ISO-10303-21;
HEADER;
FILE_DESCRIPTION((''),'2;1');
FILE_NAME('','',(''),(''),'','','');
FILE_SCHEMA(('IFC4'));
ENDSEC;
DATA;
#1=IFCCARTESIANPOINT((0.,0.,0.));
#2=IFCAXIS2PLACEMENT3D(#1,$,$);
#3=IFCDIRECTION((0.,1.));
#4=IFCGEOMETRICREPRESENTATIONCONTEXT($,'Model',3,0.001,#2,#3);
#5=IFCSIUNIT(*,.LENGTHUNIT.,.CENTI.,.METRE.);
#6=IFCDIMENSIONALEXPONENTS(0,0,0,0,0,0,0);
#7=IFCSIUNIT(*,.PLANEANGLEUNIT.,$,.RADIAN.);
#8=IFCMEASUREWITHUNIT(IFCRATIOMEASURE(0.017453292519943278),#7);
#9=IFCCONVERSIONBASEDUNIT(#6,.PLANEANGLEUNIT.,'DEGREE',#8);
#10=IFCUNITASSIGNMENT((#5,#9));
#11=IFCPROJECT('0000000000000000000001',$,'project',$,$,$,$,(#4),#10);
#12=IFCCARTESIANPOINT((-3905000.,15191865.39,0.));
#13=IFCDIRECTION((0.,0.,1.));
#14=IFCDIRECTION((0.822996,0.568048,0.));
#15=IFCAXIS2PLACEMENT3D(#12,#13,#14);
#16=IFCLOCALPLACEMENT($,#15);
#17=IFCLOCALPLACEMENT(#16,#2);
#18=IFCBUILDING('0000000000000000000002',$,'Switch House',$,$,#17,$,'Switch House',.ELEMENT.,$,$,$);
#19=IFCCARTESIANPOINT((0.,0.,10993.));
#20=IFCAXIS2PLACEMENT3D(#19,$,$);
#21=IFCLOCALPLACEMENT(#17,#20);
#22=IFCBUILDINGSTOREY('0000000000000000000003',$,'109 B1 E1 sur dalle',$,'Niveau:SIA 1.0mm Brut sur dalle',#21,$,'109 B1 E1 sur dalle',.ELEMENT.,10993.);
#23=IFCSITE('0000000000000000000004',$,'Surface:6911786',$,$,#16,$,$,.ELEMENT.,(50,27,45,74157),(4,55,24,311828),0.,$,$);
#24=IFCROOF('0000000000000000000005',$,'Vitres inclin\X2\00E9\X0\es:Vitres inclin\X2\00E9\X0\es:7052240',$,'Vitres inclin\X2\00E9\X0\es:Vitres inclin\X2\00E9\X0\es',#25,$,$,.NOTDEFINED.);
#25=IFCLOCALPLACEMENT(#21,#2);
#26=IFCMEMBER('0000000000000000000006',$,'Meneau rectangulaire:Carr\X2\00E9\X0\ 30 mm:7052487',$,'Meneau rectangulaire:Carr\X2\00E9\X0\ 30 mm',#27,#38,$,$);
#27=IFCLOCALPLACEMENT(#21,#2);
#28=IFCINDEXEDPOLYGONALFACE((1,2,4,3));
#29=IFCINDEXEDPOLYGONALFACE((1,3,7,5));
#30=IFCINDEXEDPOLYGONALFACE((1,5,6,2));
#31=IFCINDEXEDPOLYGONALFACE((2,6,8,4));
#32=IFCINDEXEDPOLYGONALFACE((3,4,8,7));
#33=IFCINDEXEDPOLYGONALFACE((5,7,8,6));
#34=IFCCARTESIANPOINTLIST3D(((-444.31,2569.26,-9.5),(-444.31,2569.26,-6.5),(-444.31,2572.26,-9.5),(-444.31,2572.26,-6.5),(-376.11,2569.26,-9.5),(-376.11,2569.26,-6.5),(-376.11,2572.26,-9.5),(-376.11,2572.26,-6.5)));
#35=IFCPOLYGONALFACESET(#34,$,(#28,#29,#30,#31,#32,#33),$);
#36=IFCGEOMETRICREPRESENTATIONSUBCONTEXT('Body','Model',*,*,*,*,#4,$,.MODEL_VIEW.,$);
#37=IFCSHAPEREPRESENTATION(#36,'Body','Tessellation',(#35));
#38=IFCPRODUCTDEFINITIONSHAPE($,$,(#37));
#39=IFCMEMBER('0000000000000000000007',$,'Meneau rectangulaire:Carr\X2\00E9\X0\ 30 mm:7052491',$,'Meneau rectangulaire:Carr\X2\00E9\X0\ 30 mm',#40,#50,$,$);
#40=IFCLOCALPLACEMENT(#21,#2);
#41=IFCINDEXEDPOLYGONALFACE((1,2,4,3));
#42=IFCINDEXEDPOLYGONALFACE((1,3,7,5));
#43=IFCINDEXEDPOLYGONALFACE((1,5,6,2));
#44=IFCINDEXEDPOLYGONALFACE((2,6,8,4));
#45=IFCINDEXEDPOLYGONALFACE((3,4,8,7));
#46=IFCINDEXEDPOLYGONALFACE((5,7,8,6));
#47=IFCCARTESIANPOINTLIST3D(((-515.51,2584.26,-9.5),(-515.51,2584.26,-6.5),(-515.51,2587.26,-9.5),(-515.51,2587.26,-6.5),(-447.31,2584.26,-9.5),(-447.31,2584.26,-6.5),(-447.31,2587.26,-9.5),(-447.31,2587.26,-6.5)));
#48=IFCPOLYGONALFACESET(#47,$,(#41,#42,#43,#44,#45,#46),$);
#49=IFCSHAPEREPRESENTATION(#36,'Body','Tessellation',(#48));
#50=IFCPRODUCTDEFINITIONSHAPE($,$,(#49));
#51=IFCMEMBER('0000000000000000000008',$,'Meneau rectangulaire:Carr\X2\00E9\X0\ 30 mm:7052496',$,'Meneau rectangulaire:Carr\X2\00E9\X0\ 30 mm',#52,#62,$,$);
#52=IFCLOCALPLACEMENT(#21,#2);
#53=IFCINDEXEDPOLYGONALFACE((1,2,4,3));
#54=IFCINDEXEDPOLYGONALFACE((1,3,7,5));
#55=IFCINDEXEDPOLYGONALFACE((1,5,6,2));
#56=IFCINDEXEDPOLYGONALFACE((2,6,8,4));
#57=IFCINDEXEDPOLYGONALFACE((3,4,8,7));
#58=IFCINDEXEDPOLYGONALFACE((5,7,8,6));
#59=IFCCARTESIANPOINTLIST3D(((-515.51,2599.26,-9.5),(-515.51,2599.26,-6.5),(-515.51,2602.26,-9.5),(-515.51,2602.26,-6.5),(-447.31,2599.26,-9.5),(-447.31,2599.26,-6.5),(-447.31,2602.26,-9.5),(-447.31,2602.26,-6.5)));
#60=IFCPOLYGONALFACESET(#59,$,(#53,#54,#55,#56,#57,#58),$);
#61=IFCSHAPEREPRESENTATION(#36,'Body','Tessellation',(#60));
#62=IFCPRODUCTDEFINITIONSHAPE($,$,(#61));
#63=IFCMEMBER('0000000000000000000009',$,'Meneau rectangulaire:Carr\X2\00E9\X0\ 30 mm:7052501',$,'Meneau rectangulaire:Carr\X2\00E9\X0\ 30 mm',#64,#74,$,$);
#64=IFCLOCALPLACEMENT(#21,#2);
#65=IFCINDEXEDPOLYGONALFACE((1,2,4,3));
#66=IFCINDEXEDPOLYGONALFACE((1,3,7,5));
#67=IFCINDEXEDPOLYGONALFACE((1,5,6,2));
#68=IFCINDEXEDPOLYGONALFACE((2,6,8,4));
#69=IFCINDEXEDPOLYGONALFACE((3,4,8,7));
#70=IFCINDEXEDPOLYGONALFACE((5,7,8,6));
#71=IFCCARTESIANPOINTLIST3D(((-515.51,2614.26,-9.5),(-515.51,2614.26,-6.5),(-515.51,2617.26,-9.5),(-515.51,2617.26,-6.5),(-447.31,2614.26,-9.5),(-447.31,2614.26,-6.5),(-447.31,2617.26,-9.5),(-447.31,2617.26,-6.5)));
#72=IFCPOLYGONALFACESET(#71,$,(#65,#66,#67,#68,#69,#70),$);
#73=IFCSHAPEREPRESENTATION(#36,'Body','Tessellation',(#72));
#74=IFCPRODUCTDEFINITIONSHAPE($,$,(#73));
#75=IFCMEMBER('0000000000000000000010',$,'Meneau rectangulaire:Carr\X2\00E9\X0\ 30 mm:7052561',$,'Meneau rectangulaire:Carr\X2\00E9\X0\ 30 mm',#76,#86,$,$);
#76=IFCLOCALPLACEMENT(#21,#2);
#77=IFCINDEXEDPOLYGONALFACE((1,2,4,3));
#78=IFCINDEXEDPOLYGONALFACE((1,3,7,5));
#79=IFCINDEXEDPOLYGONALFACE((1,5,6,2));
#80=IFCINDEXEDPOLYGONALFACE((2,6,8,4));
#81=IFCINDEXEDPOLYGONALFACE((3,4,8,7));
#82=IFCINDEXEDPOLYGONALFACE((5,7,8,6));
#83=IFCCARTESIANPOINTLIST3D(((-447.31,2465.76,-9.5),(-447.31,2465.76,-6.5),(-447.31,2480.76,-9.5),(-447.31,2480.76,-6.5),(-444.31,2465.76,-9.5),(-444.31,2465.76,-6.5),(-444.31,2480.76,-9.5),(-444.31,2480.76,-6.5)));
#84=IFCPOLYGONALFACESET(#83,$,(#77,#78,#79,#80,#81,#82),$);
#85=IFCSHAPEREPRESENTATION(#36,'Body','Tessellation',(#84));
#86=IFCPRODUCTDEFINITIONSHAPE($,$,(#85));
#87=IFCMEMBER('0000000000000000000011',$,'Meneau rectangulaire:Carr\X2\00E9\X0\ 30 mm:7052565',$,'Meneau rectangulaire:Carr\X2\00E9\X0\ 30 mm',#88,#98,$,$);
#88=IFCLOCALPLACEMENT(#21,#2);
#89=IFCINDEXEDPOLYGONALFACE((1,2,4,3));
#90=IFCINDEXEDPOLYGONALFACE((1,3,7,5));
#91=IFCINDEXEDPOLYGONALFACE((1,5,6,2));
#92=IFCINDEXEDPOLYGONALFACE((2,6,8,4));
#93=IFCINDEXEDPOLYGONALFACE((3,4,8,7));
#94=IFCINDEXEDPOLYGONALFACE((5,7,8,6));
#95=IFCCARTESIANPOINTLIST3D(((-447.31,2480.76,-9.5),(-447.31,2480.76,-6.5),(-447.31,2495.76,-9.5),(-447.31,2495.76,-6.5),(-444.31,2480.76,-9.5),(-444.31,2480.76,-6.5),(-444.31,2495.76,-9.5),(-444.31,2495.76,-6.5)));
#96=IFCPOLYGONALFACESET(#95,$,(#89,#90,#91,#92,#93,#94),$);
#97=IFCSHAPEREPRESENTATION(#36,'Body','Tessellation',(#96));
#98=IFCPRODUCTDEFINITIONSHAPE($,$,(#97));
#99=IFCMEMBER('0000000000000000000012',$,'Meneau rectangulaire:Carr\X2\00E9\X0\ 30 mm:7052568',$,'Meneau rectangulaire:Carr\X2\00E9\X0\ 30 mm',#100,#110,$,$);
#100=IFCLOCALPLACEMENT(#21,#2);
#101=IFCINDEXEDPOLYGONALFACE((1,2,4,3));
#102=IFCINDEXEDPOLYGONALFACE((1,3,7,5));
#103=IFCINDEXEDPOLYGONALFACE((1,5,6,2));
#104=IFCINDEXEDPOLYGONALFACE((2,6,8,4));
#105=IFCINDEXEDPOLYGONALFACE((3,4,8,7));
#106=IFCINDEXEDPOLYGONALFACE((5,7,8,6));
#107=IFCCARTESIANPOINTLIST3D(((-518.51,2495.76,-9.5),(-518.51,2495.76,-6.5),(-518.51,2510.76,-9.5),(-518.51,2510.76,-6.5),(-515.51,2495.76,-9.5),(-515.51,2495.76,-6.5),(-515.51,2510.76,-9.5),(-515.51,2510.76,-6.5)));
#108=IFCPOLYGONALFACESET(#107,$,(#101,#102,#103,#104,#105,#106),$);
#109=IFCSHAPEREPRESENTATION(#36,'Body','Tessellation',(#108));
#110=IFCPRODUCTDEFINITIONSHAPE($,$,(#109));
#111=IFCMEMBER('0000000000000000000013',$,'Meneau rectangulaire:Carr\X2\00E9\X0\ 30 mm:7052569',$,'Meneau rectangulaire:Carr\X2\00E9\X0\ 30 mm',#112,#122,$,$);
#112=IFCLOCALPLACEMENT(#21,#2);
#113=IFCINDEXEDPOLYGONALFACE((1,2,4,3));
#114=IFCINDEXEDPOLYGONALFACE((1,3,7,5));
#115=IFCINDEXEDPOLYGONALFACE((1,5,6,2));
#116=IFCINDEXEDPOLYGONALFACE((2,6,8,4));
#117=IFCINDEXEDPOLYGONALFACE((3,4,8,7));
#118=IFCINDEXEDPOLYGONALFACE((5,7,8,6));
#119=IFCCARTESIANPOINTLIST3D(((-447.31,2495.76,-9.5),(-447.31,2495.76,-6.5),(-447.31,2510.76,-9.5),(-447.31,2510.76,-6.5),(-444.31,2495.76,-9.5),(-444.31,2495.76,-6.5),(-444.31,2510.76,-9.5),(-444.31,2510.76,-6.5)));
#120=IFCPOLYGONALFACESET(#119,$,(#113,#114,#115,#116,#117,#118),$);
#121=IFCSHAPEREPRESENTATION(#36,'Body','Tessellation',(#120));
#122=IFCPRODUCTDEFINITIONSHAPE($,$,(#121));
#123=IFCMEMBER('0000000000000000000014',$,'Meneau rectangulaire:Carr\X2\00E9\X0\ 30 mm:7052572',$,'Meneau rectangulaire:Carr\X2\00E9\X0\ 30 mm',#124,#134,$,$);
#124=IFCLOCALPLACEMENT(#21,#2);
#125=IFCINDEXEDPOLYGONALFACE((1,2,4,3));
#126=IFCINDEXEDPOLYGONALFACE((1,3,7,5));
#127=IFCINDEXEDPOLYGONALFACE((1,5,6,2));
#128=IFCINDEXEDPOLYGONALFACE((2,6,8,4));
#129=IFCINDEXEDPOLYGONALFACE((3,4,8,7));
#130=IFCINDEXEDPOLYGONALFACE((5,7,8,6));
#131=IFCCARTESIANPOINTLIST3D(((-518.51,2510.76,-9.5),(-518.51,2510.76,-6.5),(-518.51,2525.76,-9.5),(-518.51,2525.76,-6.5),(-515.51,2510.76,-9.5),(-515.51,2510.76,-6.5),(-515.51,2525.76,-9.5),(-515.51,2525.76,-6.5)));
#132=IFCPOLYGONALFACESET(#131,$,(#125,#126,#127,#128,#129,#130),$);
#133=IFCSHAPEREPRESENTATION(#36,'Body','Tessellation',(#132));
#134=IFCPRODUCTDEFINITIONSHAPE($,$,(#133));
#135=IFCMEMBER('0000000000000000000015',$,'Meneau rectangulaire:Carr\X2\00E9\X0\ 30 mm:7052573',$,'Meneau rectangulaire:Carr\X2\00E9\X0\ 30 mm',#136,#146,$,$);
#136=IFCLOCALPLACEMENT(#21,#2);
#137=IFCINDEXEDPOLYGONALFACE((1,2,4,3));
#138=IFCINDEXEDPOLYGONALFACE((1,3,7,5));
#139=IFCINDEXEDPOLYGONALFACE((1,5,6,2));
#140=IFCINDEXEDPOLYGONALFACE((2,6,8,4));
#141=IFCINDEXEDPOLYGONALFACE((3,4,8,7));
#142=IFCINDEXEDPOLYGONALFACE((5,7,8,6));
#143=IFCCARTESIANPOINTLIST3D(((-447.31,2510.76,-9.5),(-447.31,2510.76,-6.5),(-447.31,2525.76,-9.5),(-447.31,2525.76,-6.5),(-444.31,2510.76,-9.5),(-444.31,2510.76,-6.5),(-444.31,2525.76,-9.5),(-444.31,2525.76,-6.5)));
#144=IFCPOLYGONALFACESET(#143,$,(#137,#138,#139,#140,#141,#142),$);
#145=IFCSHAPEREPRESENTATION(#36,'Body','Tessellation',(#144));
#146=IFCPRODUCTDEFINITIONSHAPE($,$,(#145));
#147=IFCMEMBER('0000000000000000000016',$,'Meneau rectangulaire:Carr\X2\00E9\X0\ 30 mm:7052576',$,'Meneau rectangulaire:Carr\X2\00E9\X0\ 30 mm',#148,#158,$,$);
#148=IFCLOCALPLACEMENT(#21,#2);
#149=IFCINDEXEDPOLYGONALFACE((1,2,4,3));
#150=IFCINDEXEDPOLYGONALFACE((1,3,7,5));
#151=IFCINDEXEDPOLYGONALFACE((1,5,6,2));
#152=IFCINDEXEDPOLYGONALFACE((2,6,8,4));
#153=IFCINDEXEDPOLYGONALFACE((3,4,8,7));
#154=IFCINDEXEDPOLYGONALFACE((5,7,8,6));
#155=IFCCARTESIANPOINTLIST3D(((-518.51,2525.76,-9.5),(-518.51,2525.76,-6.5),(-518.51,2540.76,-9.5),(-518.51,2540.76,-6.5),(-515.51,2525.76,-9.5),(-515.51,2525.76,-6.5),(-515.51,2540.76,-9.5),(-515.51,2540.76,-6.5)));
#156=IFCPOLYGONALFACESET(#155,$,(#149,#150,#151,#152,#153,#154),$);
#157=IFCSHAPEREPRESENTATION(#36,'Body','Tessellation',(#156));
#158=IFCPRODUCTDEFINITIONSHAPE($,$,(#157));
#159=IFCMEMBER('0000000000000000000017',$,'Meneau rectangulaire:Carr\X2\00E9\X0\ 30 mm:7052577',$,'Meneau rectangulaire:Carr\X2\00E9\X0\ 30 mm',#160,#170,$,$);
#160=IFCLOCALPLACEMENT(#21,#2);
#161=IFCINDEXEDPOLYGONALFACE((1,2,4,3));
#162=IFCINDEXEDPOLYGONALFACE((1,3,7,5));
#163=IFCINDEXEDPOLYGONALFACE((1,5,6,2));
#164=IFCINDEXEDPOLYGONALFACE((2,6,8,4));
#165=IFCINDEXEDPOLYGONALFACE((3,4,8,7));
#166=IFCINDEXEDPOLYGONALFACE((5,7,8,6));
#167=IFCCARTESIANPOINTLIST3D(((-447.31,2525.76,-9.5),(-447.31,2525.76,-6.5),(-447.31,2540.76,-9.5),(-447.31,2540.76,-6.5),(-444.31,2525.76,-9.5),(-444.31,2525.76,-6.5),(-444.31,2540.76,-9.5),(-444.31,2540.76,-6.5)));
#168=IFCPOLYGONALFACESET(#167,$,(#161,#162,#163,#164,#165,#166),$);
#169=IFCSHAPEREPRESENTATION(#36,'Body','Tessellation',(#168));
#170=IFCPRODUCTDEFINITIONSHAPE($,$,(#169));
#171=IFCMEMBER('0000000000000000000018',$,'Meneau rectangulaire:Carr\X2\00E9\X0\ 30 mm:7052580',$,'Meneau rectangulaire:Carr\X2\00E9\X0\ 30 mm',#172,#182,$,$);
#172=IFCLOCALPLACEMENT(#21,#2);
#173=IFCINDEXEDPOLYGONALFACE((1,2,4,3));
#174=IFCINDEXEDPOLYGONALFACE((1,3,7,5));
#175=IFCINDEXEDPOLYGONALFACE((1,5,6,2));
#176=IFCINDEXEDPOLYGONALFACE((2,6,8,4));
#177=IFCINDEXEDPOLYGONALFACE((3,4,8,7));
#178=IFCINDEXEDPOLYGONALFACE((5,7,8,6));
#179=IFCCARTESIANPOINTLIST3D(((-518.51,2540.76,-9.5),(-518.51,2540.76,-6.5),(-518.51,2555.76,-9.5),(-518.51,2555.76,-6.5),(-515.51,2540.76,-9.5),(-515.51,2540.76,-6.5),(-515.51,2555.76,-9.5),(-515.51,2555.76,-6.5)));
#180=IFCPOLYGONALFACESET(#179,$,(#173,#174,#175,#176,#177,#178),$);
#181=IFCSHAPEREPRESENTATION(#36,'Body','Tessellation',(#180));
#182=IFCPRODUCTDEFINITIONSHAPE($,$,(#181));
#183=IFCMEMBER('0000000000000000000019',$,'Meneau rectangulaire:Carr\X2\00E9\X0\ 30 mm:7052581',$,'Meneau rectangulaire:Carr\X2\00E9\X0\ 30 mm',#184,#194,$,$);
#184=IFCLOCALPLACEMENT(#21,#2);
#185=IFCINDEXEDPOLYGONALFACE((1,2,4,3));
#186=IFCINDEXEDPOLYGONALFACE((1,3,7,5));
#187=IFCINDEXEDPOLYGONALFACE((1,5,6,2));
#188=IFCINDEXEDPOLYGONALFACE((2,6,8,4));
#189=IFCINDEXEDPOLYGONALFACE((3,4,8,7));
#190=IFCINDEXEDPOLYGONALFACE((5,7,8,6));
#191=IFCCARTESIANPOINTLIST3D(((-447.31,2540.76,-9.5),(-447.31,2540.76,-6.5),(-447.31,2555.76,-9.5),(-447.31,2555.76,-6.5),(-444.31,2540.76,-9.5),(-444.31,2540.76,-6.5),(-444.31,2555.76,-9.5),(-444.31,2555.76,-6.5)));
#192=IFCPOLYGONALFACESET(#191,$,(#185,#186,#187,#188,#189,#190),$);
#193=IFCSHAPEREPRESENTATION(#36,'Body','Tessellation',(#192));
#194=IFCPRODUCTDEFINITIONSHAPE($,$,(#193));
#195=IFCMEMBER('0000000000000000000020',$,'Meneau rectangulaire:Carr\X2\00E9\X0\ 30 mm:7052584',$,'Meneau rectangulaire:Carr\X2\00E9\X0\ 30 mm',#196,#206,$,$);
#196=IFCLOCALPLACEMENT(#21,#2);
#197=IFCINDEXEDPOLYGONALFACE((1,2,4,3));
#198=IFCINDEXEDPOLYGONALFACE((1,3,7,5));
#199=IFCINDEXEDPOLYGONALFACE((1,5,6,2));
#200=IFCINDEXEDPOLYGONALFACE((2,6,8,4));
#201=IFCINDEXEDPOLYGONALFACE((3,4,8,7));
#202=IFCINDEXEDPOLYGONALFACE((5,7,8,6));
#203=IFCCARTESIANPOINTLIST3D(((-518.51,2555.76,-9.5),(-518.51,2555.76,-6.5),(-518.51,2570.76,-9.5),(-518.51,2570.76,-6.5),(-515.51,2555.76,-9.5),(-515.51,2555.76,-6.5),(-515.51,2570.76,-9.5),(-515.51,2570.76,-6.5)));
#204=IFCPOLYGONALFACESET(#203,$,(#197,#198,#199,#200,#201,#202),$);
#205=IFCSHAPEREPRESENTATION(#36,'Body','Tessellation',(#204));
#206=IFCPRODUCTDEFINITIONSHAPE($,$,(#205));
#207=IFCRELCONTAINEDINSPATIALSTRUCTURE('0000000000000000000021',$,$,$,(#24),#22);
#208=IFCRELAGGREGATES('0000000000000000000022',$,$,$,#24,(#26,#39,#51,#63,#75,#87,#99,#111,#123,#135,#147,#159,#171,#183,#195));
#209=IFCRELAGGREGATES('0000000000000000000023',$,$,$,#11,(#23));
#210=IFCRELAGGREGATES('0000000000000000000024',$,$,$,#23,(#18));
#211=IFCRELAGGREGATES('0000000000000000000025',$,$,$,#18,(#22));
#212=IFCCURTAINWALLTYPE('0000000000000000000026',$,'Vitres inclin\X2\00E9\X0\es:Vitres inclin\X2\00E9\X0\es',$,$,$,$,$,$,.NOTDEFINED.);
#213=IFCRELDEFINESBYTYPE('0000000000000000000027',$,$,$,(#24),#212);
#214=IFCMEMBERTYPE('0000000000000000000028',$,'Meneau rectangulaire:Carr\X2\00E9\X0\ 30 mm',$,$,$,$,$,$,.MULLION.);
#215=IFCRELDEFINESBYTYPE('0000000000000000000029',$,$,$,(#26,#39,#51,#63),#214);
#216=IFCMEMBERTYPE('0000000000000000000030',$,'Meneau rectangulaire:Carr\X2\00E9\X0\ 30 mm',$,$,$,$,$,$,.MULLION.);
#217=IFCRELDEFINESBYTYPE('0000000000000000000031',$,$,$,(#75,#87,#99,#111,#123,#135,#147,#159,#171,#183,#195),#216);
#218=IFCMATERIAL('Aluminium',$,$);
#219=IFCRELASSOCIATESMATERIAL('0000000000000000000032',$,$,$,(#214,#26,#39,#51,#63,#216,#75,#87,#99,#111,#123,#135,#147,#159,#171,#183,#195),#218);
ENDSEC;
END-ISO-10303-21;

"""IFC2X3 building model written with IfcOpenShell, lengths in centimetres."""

from ifc_helpers import new_model, entity, si_unit, converted_unit, direction, frame, origin, origin_2d_with_axis, place, context, subcontext, project, spatial, rectangle, extrude, source, transform, mapped, material, type_object, type_shapes, element, aggregate, save


model = new_model("IFC2X3")

# Units and contexts
model_context = context("Model", 3, precision=0.001, world=origin(), true_north=direction((0.0, 1.0)))
body_context = subcontext(model_context, "Body", "Model", "MODEL_VIEW")
ifc_project = project(units=[si_unit("LENGTHUNIT", "METRE", prefix="CENTI"), converted_unit("PLANEANGLEUNIT", "DEGREE", entity("IfcRatioMeasure", 0.017453292519943278), si_unit("PLANEANGLEUNIT", "RADIAN"), dimensions=[0, 0, 0, 0, 0, 0, 0])], contexts=[model_context])

# Site, building, storey
site_placement = place(None, frame((-3905000.0, 15191865.39, 0.0), z_axis=(0.0, 0.0, 1.0), x_axis=(0.822996, 0.568048, 0.0)))
site = spatial("IfcSite", under=ifc_project, at=site_placement, Name="Surface:6911786", CompositionType="ELEMENT", RefLatitude=(50, 27, 45, 74157), RefLongitude=(4, 55, 24, 311828), RefElevation=0.0)
building_placement = place(site_placement, origin())
building = spatial("IfcBuilding", under=site, at=building_placement, Name="Switch House", LongName="Switch House", CompositionType="ELEMENT")
storey_placement = place(building_placement, frame((0.0, 0.0, 10993.0)))
storey = spatial("IfcBuildingStorey", under=building, at=storey_placement, Name="109 B1 E1 sur dalle", ObjectType="Niveau:SIA 1.0mm Brut sur dalle", LongName="109 B1 E1 sur dalle", CompositionType="ELEMENT", Elevation=10993.0)

# Roof, members
curtain_wall_type = type_object("IfcCurtainWallType", Name="Vitres inclinées:Vitres inclinées", PredefinedType="NOTDEFINED")
roof_placement = place(storey_placement, frame((0.0, 0.0, -10993.0)))
roof = element("IfcRoof", 1, at=roof_placement, inside=storey, type_object=curtain_wall_type, Name="Vitres inclinées:Vitres inclinées:7052240", ObjectType="Vitres inclinées:Vitres inclinées", ShapeType="NOTDEFINED")
ifc_material = material(Name="Aluminium")
member_type_1 = type_object("IfcMemberType", Name="Meneau rectangulaire:Carré 30 mm", PredefinedType="MULLION", material=ifc_material)
shared_shape_1 = source(origin(), body_context, "Body", "SweptSolid", [
    extrude(rectangle(XDim=3.0, YDim=3.0, at=origin_2d_with_axis()), frame((0.0, 0.0, -68.2), z_axis=(0.0, 0.0, 1.0), x_axis=(0.0, -1.0, 0.0)), (0.0, 0.0, 1.0), 68.2),
])
type_shapes(member_type_1, [shared_shape_1])
member_1_placement = place(roof_placement, frame((-444.31, 2570.76, 10985.0), z_axis=(-1.0, 0.0, 0.0), x_axis=(0.0, 1.0, 0.0)))
member_1 = element("IfcMember", 2, at=member_1_placement, type_object=member_type_1, material=ifc_material, Name="Meneau rectangulaire:Carré 30 mm:7052487", ObjectType="Meneau rectangulaire:Carré 30 mm", context=body_context, shape_type="MappedRepresentation", body=[
    mapped(shared_shape_1, transform((0.0, 0.0, 0.0), scale=1.0)),
])
member_2_placement = place(roof_placement, frame((-515.51, 2585.76, 10985.0), z_axis=(-1.0, 0.0, 0.0), x_axis=(0.0, 1.0, 0.0)))
member_2 = element("IfcMember", 3, at=member_2_placement, type_object=member_type_1, material=ifc_material, Name="Meneau rectangulaire:Carré 30 mm:7052491", ObjectType="Meneau rectangulaire:Carré 30 mm", context=body_context, shape_type="MappedRepresentation", body=[
    mapped(shared_shape_1, transform((0.0, 0.0, 0.0), scale=1.0)),
])
member_3_placement = place(roof_placement, frame((-515.51, 2600.76, 10985.0), z_axis=(-1.0, 0.0, 0.0), x_axis=(0.0, 1.0, 0.0)))
member_3 = element("IfcMember", 4, at=member_3_placement, type_object=member_type_1, material=ifc_material, Name="Meneau rectangulaire:Carré 30 mm:7052496", ObjectType="Meneau rectangulaire:Carré 30 mm", context=body_context, shape_type="MappedRepresentation", body=[
    mapped(shared_shape_1, transform((0.0, 0.0, 0.0), scale=1.0)),
])
member_4_placement = place(roof_placement, frame((-515.51, 2615.76, 10985.0), z_axis=(-1.0, 0.0, 0.0), x_axis=(0.0, 1.0, 0.0)))
member_4 = element("IfcMember", 5, at=member_4_placement, type_object=member_type_1, material=ifc_material, Name="Meneau rectangulaire:Carré 30 mm:7052501", ObjectType="Meneau rectangulaire:Carré 30 mm", context=body_context, shape_type="MappedRepresentation", body=[
    mapped(shared_shape_1, transform((0.0, 0.0, 0.0), scale=1.0)),
])
member_type_2 = type_object("IfcMemberType", Name="Meneau rectangulaire:Carré 30 mm", PredefinedType="MULLION", material=ifc_material)
shared_shape_2 = source(origin(), body_context, "Body", "SweptSolid", [
    extrude(rectangle(XDim=3.0, YDim=3.0, at=origin_2d_with_axis()), frame((0.0, 0.0, -15.0), z_axis=(0.0, 0.0, 1.0), x_axis=(0.0, -1.0, 0.0)), (0.0, 0.0, 1.0), 15.0),
])
type_shapes(member_type_2, [shared_shape_2])
member_5_placement = place(roof_placement, frame((-445.81, 2480.76, 10985.0), z_axis=(0.0, 1.0, 0.0), x_axis=(1.0, 0.0, 0.0)))
member_5 = element("IfcMember", 6, at=member_5_placement, type_object=member_type_2, material=ifc_material, Name="Meneau rectangulaire:Carré 30 mm:7052561", ObjectType="Meneau rectangulaire:Carré 30 mm", context=body_context, shape_type="MappedRepresentation", body=[
    mapped(shared_shape_2, transform((0.0, 0.0, 0.0), scale=1.0)),
])
member_6_placement = place(roof_placement, frame((-445.81, 2495.76, 10985.0), z_axis=(0.0, 1.0, 0.0), x_axis=(1.0, 0.0, 0.0)))
member_6 = element("IfcMember", 7, at=member_6_placement, type_object=member_type_2, material=ifc_material, Name="Meneau rectangulaire:Carré 30 mm:7052565", ObjectType="Meneau rectangulaire:Carré 30 mm", context=body_context, shape_type="MappedRepresentation", body=[
    mapped(shared_shape_2, transform((0.0, 0.0, 0.0), scale=1.0)),
])
member_7_placement = place(roof_placement, frame((-517.01, 2510.76, 10985.0), z_axis=(0.0, 1.0, 0.0), x_axis=(1.0, 0.0, 0.0)))
member_7 = element("IfcMember", 8, at=member_7_placement, type_object=member_type_2, material=ifc_material, Name="Meneau rectangulaire:Carré 30 mm:7052568", ObjectType="Meneau rectangulaire:Carré 30 mm", context=body_context, shape_type="MappedRepresentation", body=[
    mapped(shared_shape_2, transform((0.0, 0.0, 0.0), scale=1.0)),
])
member_8_placement = place(roof_placement, frame((-445.81, 2510.76, 10985.0), z_axis=(0.0, 1.0, 0.0), x_axis=(1.0, 0.0, 0.0)))
member_8 = element("IfcMember", 9, at=member_8_placement, type_object=member_type_2, material=ifc_material, Name="Meneau rectangulaire:Carré 30 mm:7052569", ObjectType="Meneau rectangulaire:Carré 30 mm", context=body_context, shape_type="MappedRepresentation", body=[
    mapped(shared_shape_2, transform((0.0, 0.0, 0.0), scale=1.0)),
])
member_9_placement = place(roof_placement, frame((-517.01, 2525.76, 10985.0), z_axis=(0.0, 1.0, 0.0), x_axis=(1.0, 0.0, 0.0)))
member_9 = element("IfcMember", 10, at=member_9_placement, type_object=member_type_2, material=ifc_material, Name="Meneau rectangulaire:Carré 30 mm:7052572", ObjectType="Meneau rectangulaire:Carré 30 mm", context=body_context, shape_type="MappedRepresentation", body=[
    mapped(shared_shape_2, transform((0.0, 0.0, 0.0), scale=1.0)),
])
member_10_placement = place(roof_placement, frame((-445.81, 2525.76, 10985.0), z_axis=(0.0, 1.0, 0.0), x_axis=(1.0, 0.0, 0.0)))
member_10 = element("IfcMember", 11, at=member_10_placement, type_object=member_type_2, material=ifc_material, Name="Meneau rectangulaire:Carré 30 mm:7052573", ObjectType="Meneau rectangulaire:Carré 30 mm", context=body_context, shape_type="MappedRepresentation", body=[
    mapped(shared_shape_2, transform((0.0, 0.0, 0.0), scale=1.0)),
])
member_11_placement = place(roof_placement, frame((-517.01, 2540.76, 10985.0), z_axis=(0.0, 1.0, 0.0), x_axis=(1.0, 0.0, 0.0)))
member_11 = element("IfcMember", 12, at=member_11_placement, type_object=member_type_2, material=ifc_material, Name="Meneau rectangulaire:Carré 30 mm:7052576", ObjectType="Meneau rectangulaire:Carré 30 mm", context=body_context, shape_type="MappedRepresentation", body=[
    mapped(shared_shape_2, transform((0.0, 0.0, 0.0), scale=1.0)),
])
member_12_placement = place(roof_placement, frame((-445.81, 2540.76, 10985.0), z_axis=(0.0, 1.0, 0.0), x_axis=(1.0, 0.0, 0.0)))
member_12 = element("IfcMember", 13, at=member_12_placement, type_object=member_type_2, material=ifc_material, Name="Meneau rectangulaire:Carré 30 mm:7052577", ObjectType="Meneau rectangulaire:Carré 30 mm", context=body_context, shape_type="MappedRepresentation", body=[
    mapped(shared_shape_2, transform((0.0, 0.0, 0.0), scale=1.0)),
])
member_13_placement = place(roof_placement, frame((-517.01, 2555.76, 10985.0), z_axis=(0.0, 1.0, 0.0), x_axis=(1.0, 0.0, 0.0)))
member_13 = element("IfcMember", 14, at=member_13_placement, type_object=member_type_2, material=ifc_material, Name="Meneau rectangulaire:Carré 30 mm:7052580", ObjectType="Meneau rectangulaire:Carré 30 mm", context=body_context, shape_type="MappedRepresentation", body=[
    mapped(shared_shape_2, transform((0.0, 0.0, 0.0), scale=1.0)),
])
member_14_placement = place(roof_placement, frame((-445.81, 2555.76, 10985.0), z_axis=(0.0, 1.0, 0.0), x_axis=(1.0, 0.0, 0.0)))
member_14 = element("IfcMember", 15, at=member_14_placement, type_object=member_type_2, material=ifc_material, Name="Meneau rectangulaire:Carré 30 mm:7052581", ObjectType="Meneau rectangulaire:Carré 30 mm", context=body_context, shape_type="MappedRepresentation", body=[
    mapped(shared_shape_2, transform((0.0, 0.0, 0.0), scale=1.0)),
])
member_15_placement = place(roof_placement, frame((-517.01, 2570.76, 10985.0), z_axis=(0.0, 1.0, 0.0), x_axis=(1.0, 0.0, 0.0)))
member_15 = element("IfcMember", 16, at=member_15_placement, type_object=member_type_2, material=ifc_material, Name="Meneau rectangulaire:Carré 30 mm:7052584", ObjectType="Meneau rectangulaire:Carré 30 mm", context=body_context, shape_type="MappedRepresentation", body=[
    mapped(shared_shape_2, transform((0.0, 0.0, 0.0), scale=1.0)),
])
aggregate(roof, [member_1, member_2, member_3, member_4, member_5, member_6, member_7, member_8, member_9, member_10, member_11, member_12, member_13, member_14, member_15])

save(model, "model.ifc")
